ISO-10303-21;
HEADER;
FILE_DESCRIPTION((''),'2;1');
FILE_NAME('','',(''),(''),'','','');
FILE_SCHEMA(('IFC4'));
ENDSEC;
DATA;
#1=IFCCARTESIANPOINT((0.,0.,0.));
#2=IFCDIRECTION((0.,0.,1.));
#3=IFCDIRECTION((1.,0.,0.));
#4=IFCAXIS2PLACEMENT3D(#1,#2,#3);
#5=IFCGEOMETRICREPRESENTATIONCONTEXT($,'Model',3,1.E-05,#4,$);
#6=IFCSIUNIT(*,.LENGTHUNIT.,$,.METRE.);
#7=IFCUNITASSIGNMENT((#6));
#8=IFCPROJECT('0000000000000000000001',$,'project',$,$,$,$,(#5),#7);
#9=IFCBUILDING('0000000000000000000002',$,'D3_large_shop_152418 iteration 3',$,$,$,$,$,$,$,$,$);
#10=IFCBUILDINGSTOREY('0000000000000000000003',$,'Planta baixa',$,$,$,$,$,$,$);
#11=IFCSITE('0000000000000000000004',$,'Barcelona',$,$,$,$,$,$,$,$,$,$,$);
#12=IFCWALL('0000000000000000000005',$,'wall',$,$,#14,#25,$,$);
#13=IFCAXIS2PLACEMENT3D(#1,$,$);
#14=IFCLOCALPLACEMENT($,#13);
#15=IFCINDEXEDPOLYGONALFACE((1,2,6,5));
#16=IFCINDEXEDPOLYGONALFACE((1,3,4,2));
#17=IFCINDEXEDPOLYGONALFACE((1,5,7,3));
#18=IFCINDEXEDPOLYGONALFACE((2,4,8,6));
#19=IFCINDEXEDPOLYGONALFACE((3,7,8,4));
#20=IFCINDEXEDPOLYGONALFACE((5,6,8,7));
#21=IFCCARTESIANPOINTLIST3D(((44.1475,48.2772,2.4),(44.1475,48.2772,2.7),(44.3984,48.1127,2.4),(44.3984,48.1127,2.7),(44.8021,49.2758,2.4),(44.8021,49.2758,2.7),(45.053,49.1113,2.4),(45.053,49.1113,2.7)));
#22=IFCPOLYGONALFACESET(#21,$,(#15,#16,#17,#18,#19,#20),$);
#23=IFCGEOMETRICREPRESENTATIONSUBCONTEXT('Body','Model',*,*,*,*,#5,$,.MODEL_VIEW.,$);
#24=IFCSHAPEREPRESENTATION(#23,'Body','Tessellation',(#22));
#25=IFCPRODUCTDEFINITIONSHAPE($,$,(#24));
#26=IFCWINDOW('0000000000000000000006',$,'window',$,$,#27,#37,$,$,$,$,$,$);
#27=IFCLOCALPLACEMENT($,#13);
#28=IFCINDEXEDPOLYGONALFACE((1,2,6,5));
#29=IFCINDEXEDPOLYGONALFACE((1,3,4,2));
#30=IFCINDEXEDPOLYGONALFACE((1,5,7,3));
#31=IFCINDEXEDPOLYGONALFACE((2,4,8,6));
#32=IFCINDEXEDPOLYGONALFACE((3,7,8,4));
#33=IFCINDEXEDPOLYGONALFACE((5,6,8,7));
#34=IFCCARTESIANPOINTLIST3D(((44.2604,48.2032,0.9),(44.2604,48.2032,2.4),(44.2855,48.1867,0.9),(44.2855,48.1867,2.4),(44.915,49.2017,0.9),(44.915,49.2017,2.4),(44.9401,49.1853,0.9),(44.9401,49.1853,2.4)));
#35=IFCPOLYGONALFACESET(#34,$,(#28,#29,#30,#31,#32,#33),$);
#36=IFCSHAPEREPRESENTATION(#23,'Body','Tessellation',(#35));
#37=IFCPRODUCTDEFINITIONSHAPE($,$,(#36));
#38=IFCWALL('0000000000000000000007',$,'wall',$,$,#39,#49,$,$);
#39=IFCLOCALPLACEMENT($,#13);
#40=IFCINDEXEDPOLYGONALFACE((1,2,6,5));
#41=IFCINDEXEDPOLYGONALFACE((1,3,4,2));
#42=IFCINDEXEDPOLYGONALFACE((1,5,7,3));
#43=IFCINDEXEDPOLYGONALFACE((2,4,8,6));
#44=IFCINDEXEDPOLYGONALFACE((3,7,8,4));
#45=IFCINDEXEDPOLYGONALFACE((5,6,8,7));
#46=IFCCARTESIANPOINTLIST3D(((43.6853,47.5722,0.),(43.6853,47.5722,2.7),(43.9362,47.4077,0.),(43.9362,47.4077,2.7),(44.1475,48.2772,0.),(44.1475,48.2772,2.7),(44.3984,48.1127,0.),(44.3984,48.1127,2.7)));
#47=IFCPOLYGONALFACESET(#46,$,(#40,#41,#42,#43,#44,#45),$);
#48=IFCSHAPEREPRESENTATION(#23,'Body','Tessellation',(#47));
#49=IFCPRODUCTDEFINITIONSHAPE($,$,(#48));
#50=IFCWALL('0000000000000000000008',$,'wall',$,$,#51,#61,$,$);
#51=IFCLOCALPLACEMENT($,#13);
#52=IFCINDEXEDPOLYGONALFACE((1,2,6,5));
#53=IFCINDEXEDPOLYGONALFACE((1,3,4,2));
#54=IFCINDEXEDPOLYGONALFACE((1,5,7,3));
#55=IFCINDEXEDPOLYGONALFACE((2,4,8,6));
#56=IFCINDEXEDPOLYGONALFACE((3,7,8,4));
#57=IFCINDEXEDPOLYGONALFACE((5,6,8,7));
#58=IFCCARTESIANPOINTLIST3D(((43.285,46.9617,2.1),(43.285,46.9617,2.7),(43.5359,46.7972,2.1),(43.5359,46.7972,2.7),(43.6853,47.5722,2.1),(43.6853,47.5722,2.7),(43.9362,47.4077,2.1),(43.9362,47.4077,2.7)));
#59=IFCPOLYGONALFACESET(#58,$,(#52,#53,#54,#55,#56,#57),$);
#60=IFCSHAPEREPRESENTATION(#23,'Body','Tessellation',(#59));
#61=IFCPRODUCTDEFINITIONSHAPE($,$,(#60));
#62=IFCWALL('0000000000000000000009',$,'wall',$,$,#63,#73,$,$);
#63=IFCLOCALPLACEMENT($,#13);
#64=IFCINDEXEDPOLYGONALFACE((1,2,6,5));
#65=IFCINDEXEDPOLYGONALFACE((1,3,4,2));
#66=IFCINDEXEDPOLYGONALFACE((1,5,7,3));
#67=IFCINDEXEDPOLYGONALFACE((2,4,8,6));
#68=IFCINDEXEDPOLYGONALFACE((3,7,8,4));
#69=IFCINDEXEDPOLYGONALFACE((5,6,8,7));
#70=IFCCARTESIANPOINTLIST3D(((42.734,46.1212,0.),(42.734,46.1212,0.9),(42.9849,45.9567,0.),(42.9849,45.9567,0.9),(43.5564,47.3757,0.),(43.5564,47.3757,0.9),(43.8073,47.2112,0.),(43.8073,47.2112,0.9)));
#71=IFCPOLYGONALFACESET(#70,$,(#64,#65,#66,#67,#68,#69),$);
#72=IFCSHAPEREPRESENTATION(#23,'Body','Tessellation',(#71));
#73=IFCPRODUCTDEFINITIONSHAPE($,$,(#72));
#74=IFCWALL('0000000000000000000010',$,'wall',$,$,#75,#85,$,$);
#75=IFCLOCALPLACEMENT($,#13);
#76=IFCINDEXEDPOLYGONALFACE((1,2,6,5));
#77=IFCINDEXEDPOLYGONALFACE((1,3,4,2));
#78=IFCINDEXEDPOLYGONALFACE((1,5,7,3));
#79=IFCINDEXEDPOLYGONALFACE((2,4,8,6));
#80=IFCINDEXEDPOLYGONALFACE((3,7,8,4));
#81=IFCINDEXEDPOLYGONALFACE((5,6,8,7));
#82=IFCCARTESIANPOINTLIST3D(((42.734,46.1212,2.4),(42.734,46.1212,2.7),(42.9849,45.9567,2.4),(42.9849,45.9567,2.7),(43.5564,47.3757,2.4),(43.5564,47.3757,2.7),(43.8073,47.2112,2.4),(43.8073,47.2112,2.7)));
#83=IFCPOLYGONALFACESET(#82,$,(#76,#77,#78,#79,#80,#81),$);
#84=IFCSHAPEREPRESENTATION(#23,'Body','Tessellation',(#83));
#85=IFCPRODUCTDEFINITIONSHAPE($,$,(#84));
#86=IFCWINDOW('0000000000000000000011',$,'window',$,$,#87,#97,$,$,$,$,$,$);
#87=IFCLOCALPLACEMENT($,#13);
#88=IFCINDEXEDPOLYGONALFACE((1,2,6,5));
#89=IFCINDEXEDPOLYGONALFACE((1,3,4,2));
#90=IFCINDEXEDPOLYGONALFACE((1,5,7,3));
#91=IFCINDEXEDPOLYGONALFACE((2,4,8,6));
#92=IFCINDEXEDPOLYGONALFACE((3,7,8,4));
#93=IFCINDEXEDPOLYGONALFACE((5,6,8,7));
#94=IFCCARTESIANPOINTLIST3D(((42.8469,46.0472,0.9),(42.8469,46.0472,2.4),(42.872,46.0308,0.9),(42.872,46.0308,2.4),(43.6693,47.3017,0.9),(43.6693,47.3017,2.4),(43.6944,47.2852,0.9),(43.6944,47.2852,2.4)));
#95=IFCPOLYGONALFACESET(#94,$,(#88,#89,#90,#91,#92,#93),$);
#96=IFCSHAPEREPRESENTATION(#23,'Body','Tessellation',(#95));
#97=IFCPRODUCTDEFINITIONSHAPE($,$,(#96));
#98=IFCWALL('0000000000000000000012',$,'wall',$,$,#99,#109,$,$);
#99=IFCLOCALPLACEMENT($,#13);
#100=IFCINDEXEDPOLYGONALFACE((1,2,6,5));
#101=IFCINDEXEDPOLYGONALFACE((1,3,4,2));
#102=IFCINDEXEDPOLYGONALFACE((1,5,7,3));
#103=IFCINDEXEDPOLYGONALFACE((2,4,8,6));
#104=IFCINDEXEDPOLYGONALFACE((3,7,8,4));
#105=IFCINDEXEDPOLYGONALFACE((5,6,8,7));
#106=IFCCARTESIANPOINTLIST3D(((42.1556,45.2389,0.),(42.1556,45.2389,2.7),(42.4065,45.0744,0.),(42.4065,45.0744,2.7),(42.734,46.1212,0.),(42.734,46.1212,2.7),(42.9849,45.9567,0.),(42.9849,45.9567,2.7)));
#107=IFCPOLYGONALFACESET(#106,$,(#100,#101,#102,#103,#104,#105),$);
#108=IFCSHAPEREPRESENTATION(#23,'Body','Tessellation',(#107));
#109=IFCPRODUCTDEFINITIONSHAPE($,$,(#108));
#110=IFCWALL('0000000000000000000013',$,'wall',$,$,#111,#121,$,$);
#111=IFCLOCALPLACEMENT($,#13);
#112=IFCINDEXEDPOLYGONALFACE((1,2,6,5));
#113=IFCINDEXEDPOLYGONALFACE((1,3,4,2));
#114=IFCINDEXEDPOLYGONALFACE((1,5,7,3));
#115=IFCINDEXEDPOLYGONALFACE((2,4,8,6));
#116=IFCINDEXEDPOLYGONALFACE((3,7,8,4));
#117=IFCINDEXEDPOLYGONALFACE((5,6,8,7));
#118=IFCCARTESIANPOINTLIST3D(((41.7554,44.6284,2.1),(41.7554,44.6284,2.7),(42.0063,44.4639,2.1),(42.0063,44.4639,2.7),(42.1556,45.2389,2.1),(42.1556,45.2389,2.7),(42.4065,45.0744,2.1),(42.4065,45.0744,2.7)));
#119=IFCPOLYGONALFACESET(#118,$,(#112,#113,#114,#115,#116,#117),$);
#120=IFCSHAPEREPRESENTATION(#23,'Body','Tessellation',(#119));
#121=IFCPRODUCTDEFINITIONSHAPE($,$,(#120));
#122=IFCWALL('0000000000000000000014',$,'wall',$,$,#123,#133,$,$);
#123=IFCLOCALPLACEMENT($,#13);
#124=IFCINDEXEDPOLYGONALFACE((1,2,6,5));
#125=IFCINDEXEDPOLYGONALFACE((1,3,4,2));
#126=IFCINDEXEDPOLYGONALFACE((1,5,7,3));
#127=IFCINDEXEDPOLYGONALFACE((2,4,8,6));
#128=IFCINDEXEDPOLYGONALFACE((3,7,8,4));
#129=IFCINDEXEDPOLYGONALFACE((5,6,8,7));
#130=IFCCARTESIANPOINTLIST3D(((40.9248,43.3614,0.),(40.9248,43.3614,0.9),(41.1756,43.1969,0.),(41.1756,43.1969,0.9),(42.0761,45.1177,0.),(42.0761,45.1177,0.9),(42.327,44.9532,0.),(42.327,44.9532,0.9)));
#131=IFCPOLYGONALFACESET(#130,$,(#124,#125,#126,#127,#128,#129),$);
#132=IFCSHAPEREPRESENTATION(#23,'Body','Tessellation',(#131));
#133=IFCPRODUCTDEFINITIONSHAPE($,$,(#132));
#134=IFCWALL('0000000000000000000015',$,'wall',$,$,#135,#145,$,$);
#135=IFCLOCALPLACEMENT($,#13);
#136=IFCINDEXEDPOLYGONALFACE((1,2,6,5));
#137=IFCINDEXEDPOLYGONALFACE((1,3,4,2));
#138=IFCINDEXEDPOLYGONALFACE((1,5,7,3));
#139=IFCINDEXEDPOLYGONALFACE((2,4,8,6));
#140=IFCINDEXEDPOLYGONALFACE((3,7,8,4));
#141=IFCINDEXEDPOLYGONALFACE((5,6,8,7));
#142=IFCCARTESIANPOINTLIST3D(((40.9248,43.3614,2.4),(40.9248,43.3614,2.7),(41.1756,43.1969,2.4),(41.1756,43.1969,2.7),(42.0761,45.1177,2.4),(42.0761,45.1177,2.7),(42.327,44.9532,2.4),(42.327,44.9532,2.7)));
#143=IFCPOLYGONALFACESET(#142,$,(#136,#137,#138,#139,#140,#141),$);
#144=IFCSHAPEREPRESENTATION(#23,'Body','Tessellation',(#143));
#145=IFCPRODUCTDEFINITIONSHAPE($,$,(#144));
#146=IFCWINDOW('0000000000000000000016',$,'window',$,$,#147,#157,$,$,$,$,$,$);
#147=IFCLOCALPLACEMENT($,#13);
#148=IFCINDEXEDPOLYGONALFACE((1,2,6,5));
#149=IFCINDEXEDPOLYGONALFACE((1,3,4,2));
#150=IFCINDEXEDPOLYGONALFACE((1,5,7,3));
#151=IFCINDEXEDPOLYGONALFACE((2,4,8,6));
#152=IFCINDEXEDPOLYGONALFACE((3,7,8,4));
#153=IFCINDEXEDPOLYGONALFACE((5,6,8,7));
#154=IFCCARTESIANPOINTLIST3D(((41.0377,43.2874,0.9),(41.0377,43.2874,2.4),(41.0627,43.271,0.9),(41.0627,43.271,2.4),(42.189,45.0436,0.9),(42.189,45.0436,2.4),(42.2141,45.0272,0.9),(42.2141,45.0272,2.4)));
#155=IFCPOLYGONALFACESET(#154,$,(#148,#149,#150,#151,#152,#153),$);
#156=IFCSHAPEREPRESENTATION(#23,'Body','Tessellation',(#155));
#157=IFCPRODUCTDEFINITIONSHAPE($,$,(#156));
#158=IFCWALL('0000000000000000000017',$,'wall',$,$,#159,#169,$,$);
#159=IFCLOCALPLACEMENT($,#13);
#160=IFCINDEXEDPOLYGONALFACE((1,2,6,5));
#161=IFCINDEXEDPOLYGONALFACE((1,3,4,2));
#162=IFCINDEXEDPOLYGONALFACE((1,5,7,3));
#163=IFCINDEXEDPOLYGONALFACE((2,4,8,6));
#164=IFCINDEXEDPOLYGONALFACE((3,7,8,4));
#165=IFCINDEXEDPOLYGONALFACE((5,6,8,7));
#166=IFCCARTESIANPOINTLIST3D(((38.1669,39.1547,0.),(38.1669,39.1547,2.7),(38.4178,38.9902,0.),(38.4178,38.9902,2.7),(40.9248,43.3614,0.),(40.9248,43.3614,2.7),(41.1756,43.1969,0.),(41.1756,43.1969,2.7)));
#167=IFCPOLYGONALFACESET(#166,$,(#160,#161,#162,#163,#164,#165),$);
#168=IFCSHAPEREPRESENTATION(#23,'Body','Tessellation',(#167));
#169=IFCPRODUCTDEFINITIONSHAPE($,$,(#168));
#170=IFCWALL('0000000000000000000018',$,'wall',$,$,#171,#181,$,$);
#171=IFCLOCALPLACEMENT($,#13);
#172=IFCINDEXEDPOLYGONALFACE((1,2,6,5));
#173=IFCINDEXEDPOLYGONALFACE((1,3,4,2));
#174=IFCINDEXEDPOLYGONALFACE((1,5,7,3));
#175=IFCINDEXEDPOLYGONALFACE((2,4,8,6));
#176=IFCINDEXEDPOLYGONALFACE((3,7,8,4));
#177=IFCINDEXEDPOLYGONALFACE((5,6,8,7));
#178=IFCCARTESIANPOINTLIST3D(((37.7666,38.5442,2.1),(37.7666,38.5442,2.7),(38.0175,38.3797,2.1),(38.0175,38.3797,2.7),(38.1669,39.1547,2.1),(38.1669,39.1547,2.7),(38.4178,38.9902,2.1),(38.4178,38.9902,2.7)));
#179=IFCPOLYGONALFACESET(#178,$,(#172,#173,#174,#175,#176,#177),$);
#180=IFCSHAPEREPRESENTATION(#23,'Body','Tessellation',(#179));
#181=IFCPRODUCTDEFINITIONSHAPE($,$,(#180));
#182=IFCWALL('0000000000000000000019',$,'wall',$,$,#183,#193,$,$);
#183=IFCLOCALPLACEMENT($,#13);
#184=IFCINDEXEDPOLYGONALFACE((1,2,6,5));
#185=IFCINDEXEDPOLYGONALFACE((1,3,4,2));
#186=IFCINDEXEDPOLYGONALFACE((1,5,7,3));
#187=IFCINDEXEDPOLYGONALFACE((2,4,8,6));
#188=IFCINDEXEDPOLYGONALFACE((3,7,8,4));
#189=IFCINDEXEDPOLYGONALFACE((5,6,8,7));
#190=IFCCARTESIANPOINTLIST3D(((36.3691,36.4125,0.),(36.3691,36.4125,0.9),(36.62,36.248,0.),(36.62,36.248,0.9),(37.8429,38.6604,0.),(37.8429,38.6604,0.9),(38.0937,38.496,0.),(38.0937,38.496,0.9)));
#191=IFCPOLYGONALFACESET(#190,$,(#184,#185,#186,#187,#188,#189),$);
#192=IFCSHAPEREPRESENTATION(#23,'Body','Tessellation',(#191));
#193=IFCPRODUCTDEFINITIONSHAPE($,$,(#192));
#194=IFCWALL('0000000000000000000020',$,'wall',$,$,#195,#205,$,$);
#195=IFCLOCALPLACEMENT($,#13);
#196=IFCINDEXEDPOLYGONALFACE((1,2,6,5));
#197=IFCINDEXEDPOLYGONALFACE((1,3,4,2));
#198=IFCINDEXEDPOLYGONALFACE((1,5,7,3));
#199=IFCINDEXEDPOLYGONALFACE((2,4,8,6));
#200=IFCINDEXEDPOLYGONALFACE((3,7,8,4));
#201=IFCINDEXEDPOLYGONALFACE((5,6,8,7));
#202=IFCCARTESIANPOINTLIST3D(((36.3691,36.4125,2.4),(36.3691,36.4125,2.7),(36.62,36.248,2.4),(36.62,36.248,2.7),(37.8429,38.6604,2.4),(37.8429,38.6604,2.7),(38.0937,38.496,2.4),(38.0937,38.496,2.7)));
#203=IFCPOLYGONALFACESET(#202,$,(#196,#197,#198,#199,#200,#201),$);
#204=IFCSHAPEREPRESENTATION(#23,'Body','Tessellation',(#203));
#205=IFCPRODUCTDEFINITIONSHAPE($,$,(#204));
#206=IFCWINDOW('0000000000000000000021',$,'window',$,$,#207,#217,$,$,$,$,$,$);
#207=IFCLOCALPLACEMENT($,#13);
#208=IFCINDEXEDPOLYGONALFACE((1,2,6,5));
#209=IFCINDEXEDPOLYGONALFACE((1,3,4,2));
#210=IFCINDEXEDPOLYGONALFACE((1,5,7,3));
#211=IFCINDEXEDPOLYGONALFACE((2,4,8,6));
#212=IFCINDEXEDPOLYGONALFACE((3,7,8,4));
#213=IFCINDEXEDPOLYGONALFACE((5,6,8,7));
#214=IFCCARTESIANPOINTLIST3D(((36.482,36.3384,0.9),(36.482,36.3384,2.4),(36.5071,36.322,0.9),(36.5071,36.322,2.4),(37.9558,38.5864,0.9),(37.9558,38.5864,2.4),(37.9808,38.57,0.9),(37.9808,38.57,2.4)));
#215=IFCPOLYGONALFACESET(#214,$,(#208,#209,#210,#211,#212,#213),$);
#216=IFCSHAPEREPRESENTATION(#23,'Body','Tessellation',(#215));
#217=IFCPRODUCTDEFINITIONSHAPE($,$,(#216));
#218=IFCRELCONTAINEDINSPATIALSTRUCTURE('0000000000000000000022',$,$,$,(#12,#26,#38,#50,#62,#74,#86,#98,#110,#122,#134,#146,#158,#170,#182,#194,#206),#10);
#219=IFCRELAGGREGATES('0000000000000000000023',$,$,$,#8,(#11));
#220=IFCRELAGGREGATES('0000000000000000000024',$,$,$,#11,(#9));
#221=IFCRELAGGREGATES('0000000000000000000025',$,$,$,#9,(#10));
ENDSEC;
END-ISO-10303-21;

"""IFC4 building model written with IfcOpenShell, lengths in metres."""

from ifc_helpers import new_model, si_unit, frame, origin, origin_with_axes, place, context, subcontext, project, spatial, polyline, outline, extrude, element, save


model = new_model("IFC4")

# Units and contexts
model_context = context("Model", 3, precision=1e-05, world=origin_with_axes())
body_context = subcontext(model_context, "Body", "Model", "MODEL_VIEW")
ifc_project = project(units=[si_unit("LENGTHUNIT", "METRE")], contexts=[model_context])

# Site, building, storey
site = spatial("IfcSite", under=ifc_project, Name="Barcelona")
building = spatial("IfcBuilding", under=site, Name="D3_large_shop_152418 iteration 3")
storey = spatial("IfcBuildingStorey", under=building, Name="Planta baixa")

# Wall
wall_1_placement = place(None, origin_with_axes())
element("IfcWall", 1, at=wall_1_placement, inside=storey, Name="wall", context=body_context, shape_type="SweptSolid", body=[
    extrude(outline(polyline([(45.053, 49.1113), (44.3984, 48.1127), (44.1475, 48.2772), (44.8021, 49.2758), (45.053, 49.1113)])), frame((0.0, 0.0, 2.4)), (0.0, 0.0, 1.0), 0.3),
])

# Window
window_1_placement = place(None, origin_with_axes())
element("IfcWindow", 2, at=window_1_placement, inside=storey, Name="window", context=body_context, shape_type="SweptSolid", body=[
    extrude(outline(polyline([(44.9401, 49.1853), (44.2855, 48.1867), (44.2604, 48.2032), (44.915, 49.2017), (44.9401, 49.1853)])), frame((0.0, 0.0, 0.9)), (0.0, 0.0, 1.0), 1.5),
])

# Walls
wall_2_placement = place(None, origin_with_axes())
element("IfcWall", 3, at=wall_2_placement, inside=storey, Name="wall", context=body_context, shape_type="SweptSolid", body=[
    extrude(outline(polyline([(44.3984, 48.1127), (43.9362, 47.4077), (43.6853, 47.5722), (44.1475, 48.2772), (44.3984, 48.1127)])), origin(), (0.0, 0.0, 1.0), 2.7),
])
wall_3_placement = place(None, origin_with_axes())
element("IfcWall", 4, at=wall_3_placement, inside=storey, Name="wall", context=body_context, shape_type="SweptSolid", body=[
    extrude(outline(polyline([(43.9362, 47.4077), (43.5359, 46.7972), (43.285, 46.9617), (43.6853, 47.5722), (43.9362, 47.4077)])), frame((0.0, 0.0, 2.1)), (0.0, 0.0, 1.0), 0.6),
])
wall_4_placement = place(None, origin_with_axes())
element("IfcWall", 5, at=wall_4_placement, inside=storey, Name="wall", context=body_context, shape_type="SweptSolid", body=[
    extrude(outline(polyline([(43.8073, 47.2112), (42.9849, 45.9567), (42.734, 46.1212), (43.5564, 47.3757), (43.8073, 47.2112)])), origin(), (0.0, 0.0, 1.0), 0.9),
])
wall_5_placement = place(None, origin_with_axes())
element("IfcWall", 6, at=wall_5_placement, inside=storey, Name="wall", context=body_context, shape_type="SweptSolid", body=[
    extrude(outline(polyline([(43.8073, 47.2112), (42.9849, 45.9567), (42.734, 46.1212), (43.5564, 47.3757), (43.8073, 47.2112)])), frame((0.0, 0.0, 2.4)), (0.0, 0.0, 1.0), 0.3),
])

# Window
window_2_placement = place(None, origin_with_axes())
element("IfcWindow", 7, at=window_2_placement, inside=storey, Name="window", context=body_context, shape_type="SweptSolid", body=[
    extrude(outline(polyline([(43.6944, 47.2852), (42.872, 46.0308), (42.8469, 46.0472), (43.6693, 47.3017), (43.6944, 47.2852)])), frame((0.0, 0.0, 0.9)), (0.0, 0.0, 1.0), 1.5),
])

# Walls
wall_6_placement = place(None, origin_with_axes())
element("IfcWall", 8, at=wall_6_placement, inside=storey, Name="wall", context=body_context, shape_type="SweptSolid", body=[
    extrude(outline(polyline([(42.9849, 45.9567), (42.4065, 45.0744), (42.1556, 45.2389), (42.734, 46.1212), (42.9849, 45.9567)])), origin(), (0.0, 0.0, 1.0), 2.7),
])
wall_7_placement = place(None, origin_with_axes())
element("IfcWall", 9, at=wall_7_placement, inside=storey, Name="wall", context=body_context, shape_type="SweptSolid", body=[
    extrude(outline(polyline([(42.4065, 45.0744), (42.0063, 44.4639), (41.7554, 44.6284), (42.1556, 45.2389), (42.4065, 45.0744)])), frame((0.0, 0.0, 2.1)), (0.0, 0.0, 1.0), 0.6),
])
wall_8_placement = place(None, origin_with_axes())
element("IfcWall", 10, at=wall_8_placement, inside=storey, Name="wall", context=body_context, shape_type="SweptSolid", body=[
    extrude(outline(polyline([(42.327, 44.9532), (41.1756, 43.1969), (40.9248, 43.3614), (42.0761, 45.1177), (42.327, 44.9532)])), origin(), (0.0, 0.0, 1.0), 0.9),
])
wall_9_placement = place(None, origin_with_axes())
element("IfcWall", 11, at=wall_9_placement, inside=storey, Name="wall", context=body_context, shape_type="SweptSolid", body=[
    extrude(outline(polyline([(42.327, 44.9532), (41.1756, 43.1969), (40.9248, 43.3614), (42.0761, 45.1177), (42.327, 44.9532)])), frame((0.0, 0.0, 2.4)), (0.0, 0.0, 1.0), 0.3),
])

# Window
window_3_placement = place(None, origin_with_axes())
element("IfcWindow", 12, at=window_3_placement, inside=storey, Name="window", context=body_context, shape_type="SweptSolid", body=[
    extrude(outline(polyline([(42.2141, 45.0272), (41.0627, 43.271), (41.0377, 43.2874), (42.189, 45.0436), (42.2141, 45.0272)])), frame((0.0, 0.0, 0.9)), (0.0, 0.0, 1.0), 1.5),
])

# Walls
wall_10_placement = place(None, origin_with_axes())
element("IfcWall", 13, at=wall_10_placement, inside=storey, Name="wall", context=body_context, shape_type="SweptSolid", body=[
    extrude(outline(polyline([(41.1756, 43.1969), (38.4178, 38.9902), (38.1669, 39.1547), (40.9248, 43.3614), (41.1756, 43.1969)])), origin(), (0.0, 0.0, 1.0), 2.7),
])
wall_11_placement = place(None, origin_with_axes())
element("IfcWall", 14, at=wall_11_placement, inside=storey, Name="wall", context=body_context, shape_type="SweptSolid", body=[
    extrude(outline(polyline([(38.4178, 38.9902), (38.0175, 38.3797), (37.7666, 38.5442), (38.1669, 39.1547), (38.4178, 38.9902)])), frame((0.0, 0.0, 2.1)), (0.0, 0.0, 1.0), 0.6),
])
wall_12_placement = place(None, origin_with_axes())
element("IfcWall", 15, at=wall_12_placement, inside=storey, Name="wall", context=body_context, shape_type="SweptSolid", body=[
    extrude(outline(polyline([(38.0937, 38.496), (36.62, 36.248), (36.3691, 36.4125), (37.8429, 38.6604), (38.0937, 38.496)])), origin(), (0.0, 0.0, 1.0), 0.9),
])
wall_13_placement = place(None, origin_with_axes())
element("IfcWall", 16, at=wall_13_placement, inside=storey, Name="wall", context=body_context, shape_type="SweptSolid", body=[
    extrude(outline(polyline([(38.0937, 38.496), (36.62, 36.248), (36.3691, 36.4125), (37.8429, 38.6604), (38.0937, 38.496)])), frame((0.0, 0.0, 2.4)), (0.0, 0.0, 1.0), 0.3),
])

# Window
window_4_placement = place(None, origin_with_axes())
element("IfcWindow", 17, at=window_4_placement, inside=storey, Name="window", context=body_context, shape_type="SweptSolid", body=[
    extrude(outline(polyline([(37.9808, 38.57), (36.5071, 36.322), (36.482, 36.3384), (37.9558, 38.5864), (37.9808, 38.57)])), frame((0.0, 0.0, 0.9)), (0.0, 0.0, 1.0), 1.5),
])

save(model, "model.ifc")
